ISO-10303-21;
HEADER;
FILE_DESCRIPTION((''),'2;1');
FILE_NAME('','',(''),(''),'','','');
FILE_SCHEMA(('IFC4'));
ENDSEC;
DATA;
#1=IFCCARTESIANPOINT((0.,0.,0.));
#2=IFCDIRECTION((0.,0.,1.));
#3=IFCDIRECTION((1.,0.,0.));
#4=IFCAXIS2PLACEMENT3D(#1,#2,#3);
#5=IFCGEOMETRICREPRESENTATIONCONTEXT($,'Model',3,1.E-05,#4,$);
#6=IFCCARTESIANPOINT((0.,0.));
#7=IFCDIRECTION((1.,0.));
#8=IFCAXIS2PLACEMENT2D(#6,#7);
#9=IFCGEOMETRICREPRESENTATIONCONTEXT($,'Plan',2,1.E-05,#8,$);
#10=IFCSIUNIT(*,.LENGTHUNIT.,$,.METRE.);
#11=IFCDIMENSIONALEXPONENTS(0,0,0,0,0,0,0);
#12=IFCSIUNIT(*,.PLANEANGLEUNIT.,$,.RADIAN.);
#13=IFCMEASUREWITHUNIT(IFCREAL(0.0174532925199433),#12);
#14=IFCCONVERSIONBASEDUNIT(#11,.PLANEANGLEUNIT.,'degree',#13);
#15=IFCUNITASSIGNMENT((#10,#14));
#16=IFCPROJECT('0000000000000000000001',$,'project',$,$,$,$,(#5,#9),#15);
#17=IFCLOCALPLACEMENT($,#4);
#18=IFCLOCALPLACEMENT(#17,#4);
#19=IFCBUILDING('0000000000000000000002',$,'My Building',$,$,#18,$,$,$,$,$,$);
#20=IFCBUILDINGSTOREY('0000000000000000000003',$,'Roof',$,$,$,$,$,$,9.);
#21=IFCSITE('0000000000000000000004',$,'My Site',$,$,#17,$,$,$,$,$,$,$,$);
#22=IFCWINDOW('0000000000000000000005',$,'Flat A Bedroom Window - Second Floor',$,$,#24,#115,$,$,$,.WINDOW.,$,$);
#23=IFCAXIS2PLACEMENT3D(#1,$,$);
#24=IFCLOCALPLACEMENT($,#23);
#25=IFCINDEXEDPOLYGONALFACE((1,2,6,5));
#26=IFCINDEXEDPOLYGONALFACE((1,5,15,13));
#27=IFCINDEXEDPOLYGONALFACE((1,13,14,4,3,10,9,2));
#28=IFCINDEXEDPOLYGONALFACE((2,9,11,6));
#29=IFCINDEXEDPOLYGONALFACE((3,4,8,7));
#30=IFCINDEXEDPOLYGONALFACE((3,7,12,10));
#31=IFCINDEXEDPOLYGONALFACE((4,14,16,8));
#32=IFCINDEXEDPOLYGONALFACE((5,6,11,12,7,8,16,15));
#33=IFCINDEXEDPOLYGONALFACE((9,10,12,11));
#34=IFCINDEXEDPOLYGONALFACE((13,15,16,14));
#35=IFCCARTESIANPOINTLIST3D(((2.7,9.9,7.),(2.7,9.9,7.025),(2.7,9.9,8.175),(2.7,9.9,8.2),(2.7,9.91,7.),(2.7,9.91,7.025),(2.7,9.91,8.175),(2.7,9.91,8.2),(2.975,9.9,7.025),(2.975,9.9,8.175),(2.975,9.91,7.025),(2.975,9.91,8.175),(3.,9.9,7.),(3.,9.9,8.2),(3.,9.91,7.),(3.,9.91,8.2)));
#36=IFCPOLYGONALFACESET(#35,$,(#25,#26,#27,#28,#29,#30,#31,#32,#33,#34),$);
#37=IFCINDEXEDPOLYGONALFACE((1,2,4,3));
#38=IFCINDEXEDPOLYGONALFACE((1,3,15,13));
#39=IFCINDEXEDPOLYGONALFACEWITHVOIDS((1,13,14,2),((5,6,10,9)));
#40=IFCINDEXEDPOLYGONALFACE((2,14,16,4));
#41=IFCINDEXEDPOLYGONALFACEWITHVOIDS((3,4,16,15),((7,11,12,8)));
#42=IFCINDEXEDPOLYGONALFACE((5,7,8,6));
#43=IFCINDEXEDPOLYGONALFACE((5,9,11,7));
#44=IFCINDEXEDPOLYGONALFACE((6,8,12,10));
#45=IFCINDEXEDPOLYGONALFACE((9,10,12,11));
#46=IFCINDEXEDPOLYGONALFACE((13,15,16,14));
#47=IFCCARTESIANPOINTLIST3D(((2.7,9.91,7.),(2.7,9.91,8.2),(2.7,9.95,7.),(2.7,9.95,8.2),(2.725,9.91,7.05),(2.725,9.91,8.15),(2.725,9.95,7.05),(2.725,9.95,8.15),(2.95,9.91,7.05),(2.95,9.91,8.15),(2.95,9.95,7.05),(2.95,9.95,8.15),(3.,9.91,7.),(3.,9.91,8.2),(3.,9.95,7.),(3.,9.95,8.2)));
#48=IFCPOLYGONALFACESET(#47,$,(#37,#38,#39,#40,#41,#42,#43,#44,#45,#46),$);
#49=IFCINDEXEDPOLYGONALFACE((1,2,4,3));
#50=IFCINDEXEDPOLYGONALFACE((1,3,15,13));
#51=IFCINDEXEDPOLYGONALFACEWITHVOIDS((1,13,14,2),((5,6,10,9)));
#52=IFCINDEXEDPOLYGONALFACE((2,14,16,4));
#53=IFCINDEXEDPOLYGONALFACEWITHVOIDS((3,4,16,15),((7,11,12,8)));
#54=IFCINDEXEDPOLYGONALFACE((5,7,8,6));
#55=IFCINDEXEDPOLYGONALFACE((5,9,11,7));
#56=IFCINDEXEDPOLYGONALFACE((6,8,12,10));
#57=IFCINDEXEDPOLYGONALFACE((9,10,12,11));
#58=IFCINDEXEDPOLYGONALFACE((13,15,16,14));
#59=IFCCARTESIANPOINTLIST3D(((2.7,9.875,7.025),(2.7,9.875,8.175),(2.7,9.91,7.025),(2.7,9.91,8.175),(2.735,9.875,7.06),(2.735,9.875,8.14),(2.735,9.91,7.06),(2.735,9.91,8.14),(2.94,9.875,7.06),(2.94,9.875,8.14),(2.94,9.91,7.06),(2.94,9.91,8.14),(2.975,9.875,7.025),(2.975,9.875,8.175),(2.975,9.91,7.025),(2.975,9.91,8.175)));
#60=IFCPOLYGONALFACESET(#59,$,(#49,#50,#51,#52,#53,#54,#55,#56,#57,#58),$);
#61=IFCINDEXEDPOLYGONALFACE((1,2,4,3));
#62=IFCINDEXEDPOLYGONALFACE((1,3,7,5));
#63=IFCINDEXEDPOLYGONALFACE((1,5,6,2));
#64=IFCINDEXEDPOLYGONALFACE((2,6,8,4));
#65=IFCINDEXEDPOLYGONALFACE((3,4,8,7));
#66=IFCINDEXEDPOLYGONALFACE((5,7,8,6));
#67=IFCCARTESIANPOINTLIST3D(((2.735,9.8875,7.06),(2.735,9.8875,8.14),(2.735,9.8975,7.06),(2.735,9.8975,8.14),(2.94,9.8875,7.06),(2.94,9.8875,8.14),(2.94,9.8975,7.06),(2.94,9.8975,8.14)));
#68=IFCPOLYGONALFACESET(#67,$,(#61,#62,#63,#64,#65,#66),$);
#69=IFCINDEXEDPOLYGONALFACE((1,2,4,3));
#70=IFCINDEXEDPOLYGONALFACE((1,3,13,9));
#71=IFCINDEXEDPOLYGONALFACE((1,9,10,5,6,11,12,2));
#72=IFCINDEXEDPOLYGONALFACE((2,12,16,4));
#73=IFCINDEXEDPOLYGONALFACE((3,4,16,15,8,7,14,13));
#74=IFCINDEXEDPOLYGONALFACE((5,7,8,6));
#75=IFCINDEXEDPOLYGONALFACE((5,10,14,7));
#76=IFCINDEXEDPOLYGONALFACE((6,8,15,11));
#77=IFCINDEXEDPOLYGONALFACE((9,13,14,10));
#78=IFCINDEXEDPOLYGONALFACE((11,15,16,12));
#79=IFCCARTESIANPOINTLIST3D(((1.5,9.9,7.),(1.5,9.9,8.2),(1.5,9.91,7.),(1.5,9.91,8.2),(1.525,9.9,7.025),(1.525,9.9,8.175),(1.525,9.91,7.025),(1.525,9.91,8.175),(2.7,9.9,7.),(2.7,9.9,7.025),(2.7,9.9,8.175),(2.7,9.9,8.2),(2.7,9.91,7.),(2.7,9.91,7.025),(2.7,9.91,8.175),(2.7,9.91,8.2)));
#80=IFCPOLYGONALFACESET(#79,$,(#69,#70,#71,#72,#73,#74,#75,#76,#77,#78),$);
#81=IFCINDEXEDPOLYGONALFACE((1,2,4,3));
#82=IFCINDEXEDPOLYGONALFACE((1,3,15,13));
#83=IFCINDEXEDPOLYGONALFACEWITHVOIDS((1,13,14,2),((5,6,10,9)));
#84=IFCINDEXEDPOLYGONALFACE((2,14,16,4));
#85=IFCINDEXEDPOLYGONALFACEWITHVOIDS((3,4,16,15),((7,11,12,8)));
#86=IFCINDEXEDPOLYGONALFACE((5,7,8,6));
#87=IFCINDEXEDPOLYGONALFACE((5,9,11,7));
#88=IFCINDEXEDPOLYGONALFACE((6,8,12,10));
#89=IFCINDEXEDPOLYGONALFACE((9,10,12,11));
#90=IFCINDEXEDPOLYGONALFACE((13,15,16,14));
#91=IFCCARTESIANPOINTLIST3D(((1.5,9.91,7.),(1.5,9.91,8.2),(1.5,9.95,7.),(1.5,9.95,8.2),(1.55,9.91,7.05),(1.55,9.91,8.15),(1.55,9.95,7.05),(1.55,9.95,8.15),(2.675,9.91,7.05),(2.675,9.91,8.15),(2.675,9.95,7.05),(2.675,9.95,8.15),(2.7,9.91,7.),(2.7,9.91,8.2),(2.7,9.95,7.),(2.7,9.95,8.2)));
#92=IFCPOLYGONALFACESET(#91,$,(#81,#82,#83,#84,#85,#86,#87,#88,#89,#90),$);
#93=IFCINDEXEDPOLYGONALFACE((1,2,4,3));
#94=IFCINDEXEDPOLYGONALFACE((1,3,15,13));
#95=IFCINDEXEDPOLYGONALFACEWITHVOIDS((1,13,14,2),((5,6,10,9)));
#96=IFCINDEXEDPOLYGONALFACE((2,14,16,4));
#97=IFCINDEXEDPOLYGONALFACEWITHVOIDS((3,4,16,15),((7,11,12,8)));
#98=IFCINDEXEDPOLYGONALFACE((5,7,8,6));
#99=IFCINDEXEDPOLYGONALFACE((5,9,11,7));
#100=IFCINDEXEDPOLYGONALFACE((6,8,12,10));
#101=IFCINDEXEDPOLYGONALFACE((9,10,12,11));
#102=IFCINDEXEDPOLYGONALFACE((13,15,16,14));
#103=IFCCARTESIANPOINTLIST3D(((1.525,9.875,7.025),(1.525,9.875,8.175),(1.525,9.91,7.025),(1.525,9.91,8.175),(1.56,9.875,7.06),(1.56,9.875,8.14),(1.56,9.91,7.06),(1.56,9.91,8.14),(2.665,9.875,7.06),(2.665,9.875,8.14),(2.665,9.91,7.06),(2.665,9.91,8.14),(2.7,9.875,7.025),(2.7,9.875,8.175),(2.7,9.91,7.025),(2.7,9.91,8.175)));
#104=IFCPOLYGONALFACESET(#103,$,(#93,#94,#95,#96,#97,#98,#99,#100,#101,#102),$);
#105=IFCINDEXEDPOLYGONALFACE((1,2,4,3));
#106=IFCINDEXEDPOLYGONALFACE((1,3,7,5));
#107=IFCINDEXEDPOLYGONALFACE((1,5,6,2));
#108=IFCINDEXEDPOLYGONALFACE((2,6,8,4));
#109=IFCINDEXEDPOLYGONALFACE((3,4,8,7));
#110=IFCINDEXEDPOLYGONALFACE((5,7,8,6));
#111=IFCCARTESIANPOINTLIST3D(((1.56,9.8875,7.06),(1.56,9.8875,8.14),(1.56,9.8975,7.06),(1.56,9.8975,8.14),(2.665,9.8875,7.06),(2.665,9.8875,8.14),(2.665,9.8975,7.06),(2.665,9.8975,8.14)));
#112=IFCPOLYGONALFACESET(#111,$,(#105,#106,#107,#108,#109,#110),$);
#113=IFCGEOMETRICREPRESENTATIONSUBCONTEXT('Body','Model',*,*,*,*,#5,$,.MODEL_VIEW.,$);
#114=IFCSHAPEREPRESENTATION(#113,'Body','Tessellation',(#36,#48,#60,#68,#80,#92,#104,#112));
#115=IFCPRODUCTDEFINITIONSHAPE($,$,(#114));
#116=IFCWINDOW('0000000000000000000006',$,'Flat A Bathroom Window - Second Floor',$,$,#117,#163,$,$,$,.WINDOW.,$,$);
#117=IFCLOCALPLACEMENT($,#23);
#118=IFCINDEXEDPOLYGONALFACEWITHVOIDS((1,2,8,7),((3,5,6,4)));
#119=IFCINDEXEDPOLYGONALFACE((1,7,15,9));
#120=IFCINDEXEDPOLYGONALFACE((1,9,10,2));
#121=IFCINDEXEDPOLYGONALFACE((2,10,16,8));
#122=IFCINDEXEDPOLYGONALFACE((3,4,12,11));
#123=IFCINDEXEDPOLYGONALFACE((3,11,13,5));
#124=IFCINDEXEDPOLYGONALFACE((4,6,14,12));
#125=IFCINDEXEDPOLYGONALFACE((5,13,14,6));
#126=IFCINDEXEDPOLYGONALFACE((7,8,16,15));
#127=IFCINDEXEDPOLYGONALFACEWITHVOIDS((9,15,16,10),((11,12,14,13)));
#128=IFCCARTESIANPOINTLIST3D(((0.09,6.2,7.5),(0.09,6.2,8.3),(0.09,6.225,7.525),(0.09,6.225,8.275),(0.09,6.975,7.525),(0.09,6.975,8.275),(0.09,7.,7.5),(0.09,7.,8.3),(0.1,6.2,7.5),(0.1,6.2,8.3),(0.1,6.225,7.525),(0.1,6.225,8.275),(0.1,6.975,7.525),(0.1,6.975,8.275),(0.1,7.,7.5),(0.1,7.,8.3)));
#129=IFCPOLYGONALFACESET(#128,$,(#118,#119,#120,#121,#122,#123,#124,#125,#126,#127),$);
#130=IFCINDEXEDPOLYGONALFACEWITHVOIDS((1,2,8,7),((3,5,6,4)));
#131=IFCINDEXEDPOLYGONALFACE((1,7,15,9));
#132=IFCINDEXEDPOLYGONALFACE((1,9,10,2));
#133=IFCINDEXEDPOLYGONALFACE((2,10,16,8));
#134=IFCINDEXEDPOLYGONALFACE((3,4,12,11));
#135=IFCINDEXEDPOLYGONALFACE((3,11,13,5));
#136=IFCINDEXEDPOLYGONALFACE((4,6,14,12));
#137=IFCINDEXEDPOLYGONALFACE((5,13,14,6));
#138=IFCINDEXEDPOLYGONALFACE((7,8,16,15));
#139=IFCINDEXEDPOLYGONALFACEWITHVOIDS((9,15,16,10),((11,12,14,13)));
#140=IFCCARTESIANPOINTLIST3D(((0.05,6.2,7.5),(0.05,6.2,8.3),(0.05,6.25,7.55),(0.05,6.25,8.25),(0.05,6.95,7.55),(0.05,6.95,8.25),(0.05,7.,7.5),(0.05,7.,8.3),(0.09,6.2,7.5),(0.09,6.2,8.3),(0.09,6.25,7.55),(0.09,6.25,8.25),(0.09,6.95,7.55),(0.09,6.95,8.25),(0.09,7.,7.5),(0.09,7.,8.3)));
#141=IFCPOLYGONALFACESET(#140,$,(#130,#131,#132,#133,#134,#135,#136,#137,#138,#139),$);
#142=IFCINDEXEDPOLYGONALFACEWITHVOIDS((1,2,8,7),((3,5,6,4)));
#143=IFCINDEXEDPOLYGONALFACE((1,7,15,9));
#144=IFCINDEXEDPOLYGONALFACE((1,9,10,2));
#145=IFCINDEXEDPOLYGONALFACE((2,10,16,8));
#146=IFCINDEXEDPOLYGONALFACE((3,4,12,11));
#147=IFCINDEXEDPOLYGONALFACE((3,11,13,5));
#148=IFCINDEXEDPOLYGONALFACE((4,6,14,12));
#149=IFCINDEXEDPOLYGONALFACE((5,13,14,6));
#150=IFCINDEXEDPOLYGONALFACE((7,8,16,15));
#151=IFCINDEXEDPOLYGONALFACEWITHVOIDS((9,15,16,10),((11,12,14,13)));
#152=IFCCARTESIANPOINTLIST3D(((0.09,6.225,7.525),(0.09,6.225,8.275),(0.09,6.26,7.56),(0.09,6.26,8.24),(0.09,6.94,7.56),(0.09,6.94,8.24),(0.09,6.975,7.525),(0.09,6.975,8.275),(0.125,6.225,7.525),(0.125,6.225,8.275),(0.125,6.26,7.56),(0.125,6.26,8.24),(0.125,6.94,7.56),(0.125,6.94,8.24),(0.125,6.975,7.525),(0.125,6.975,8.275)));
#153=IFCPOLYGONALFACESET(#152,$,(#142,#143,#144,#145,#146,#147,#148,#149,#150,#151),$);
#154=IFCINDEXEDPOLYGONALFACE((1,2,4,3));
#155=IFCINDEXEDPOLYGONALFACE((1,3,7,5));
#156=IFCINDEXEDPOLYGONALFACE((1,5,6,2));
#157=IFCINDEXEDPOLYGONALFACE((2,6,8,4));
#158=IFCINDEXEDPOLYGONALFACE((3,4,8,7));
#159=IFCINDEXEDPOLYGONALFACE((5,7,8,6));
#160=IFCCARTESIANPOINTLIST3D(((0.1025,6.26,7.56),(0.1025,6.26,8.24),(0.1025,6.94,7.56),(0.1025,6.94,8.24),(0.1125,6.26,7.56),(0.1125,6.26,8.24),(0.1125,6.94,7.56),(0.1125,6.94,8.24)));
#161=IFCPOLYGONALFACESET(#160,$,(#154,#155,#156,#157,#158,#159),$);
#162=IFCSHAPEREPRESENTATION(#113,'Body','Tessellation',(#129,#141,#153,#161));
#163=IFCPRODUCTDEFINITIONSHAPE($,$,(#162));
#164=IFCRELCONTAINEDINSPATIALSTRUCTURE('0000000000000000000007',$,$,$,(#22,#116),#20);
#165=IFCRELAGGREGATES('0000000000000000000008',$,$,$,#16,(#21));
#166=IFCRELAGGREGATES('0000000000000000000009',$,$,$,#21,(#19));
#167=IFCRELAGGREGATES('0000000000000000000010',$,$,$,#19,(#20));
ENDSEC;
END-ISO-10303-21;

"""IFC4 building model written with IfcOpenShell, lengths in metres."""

from ifc_helpers import new_model, entity, si_unit, converted_unit, frame, origin_with_axes, origin_2d_with_axis, place, context, subcontext, project, spatial, line, indexed_curve, outline, extrude, element, save


model = new_model("IFC4")

# Units and contexts
model_context = context("Model", 3, precision=1e-05, world=origin_with_axes())
plan_context = context("Plan", 2, precision=1e-05, world=origin_2d_with_axis())
body_context = subcontext(model_context, "Body", "Model", "MODEL_VIEW")
ifc_project = project(units=[si_unit("LENGTHUNIT", "METRE"), converted_unit("PLANEANGLEUNIT", "degree", entity("IfcReal", 0.0174532925199433), si_unit("PLANEANGLEUNIT", "RADIAN"), dimensions=[0, 0, 0, 0, 0, 0, 0])], contexts=[model_context, plan_context])

# Site, building, storey
site_placement = place(None, origin_with_axes())
site = spatial("IfcSite", under=ifc_project, at=site_placement, Name="My Site")
building_placement = place(site_placement, origin_with_axes())
building = spatial("IfcBuilding", under=site, at=building_placement, Name="My Building")
storey = spatial("IfcBuildingStorey", under=building, Name="Roof", Elevation=9.0)

# Windows
window_1_placement = place(None, frame((3.0, 10.0, 7.0), z_axis=(0.0, 0.0, 1.0), x_axis=(-1.0, 0.0, 0.0)))
element("IfcWindow", 1, at=window_1_placement, inside=storey, Name="Flat A Bedroom Window - Second Floor", PredefinedType="WINDOW", context=body_context, shape_type="SweptSolid", body=[
    extrude(outline(indexed_curve([(0.3, 0.0), (0.0, 0.0), (0.0, 1.2), (0.3, 1.2), (0.3, 1.175), (0.025, 1.175), (0.025, 0.025), (0.3, 0.025)], segments=[line(1, 2, 3, 4, 5, 6, 7, 8, 1)])), frame((0.0, 0.09, 0.0), z_axis=(0.0, -1.0, 0.0), x_axis=(1.0, 0.0, 0.0)), (0.0, 0.0, -1.0), 0.01),
    extrude(outline(indexed_curve([(0.0, 0.0), (0.3, 0.0), (0.3, 1.2), (0.0, 1.2)], segments=[line(1, 2, 3, 4, 1)]), holes=[indexed_curve([(0.05, 0.05), (0.275, 0.05), (0.275, 1.15), (0.05, 1.15)], segments=[line(1, 2, 3, 4, 1)])]), frame((0.0, 0.05, 0.0), z_axis=(0.0, -1.0, 0.0), x_axis=(1.0, 0.0, 0.0)), (0.0, 0.0, -1.0), 0.04),
    extrude(outline(indexed_curve([(0.0, 0.0), (0.275, 0.0), (0.275, 1.15), (0.0, 1.15)], segments=[line(1, 2, 3, 4, 1)]), holes=[indexed_curve([(0.035, 0.035), (0.24, 0.035), (0.24, 1.115), (0.035, 1.115)], segments=[line(1, 2, 3, 4, 1)])]), frame((0.025, 0.09, 0.025), z_axis=(0.0, -1.0, 0.0), x_axis=(1.0, 0.0, 0.0)), (0.0, 0.0, -1.0), 0.035),
    extrude(outline(indexed_curve([(0.035, 0.035), (0.24, 0.035), (0.24, 1.115), (0.035, 1.115)], segments=[line(1, 2, 3, 4, 1)])), frame((0.025, 0.1025, 0.025), z_axis=(0.0, -1.0, 0.0), x_axis=(1.0, 0.0, 0.0)), (0.0, 0.0, -1.0), 0.01),
    extrude(outline(indexed_curve([(0.0, 1.2), (1.2, 1.2), (1.2, 0.0), (0.0, 0.0), (0.0, 0.025), (1.175, 0.025), (1.175, 1.175), (0.0, 1.175)], segments=[line(1, 2, 3, 4, 5, 6, 7, 8, 1)])), frame((0.3, 0.09, 0.0), z_axis=(0.0, -1.0, 0.0), x_axis=(1.0, 0.0, 0.0)), (0.0, 0.0, -1.0), 0.01),
    extrude(outline(indexed_curve([(0.0, 0.0), (1.2, 0.0), (1.2, 1.2), (0.0, 1.2)], segments=[line(1, 2, 3, 4, 1)]), holes=[indexed_curve([(0.025, 0.05), (1.15, 0.05), (1.15, 1.15), (0.025, 1.15)], segments=[line(1, 2, 3, 4, 1)])]), frame((0.3, 0.05, 0.0), z_axis=(0.0, -1.0, 0.0), x_axis=(1.0, 0.0, 0.0)), (0.0, 0.0, -1.0), 0.04),
    extrude(outline(indexed_curve([(0.0, 0.0), (1.175, 0.0), (1.175, 1.15), (0.0, 1.15)], segments=[line(1, 2, 3, 4, 1)]), holes=[indexed_curve([(0.035, 0.035), (1.14, 0.035), (1.14, 1.115), (0.035, 1.115)], segments=[line(1, 2, 3, 4, 1)])]), frame((0.3, 0.09, 0.025), z_axis=(0.0, -1.0, 0.0), x_axis=(1.0, 0.0, 0.0)), (0.0, 0.0, -1.0), 0.035),
    extrude(outline(indexed_curve([(0.035, 0.035), (1.14, 0.035), (1.14, 1.115), (0.035, 1.115)], segments=[line(1, 2, 3, 4, 1)])), frame((0.3, 0.1025, 0.025), z_axis=(0.0, -1.0, 0.0), x_axis=(1.0, 0.0, 0.0)), (0.0, 0.0, -1.0), 0.01),
])
window_2_placement = place(None, frame((0.0, 7.0, 7.5), z_axis=(0.0, 0.0, 1.0), x_axis=(0.0, -1.0, 0.0)))
element("IfcWindow", 2, at=window_2_placement, inside=storey, Name="Flat A Bathroom Window - Second Floor", PredefinedType="WINDOW", context=body_context, shape_type="SweptSolid", body=[
    extrude(outline(indexed_curve([(0.0, 0.0), (0.8, 0.0), (0.8, 0.8), (0.0, 0.8)], segments=[line(1, 2, 3, 4, 1)]), holes=[indexed_curve([(0.025, 0.025), (0.775, 0.025), (0.775, 0.775), (0.025, 0.775)], segments=[line(1, 2, 3, 4, 1)])]), frame((0.0, 0.09, 0.0), z_axis=(0.0, -1.0, 0.0), x_axis=(1.0, 0.0, 0.0)), (0.0, 0.0, -1.0), 0.01),
    extrude(outline(indexed_curve([(0.0, 0.0), (0.8, 0.0), (0.8, 0.8), (0.0, 0.8)], segments=[line(1, 2, 3, 4, 1)]), holes=[indexed_curve([(0.05, 0.05), (0.75, 0.05), (0.75, 0.75), (0.05, 0.75)], segments=[line(1, 2, 3, 4, 1)])]), frame((0.0, 0.05, 0.0), z_axis=(0.0, -1.0, 0.0), x_axis=(1.0, 0.0, 0.0)), (0.0, 0.0, -1.0), 0.04),
    extrude(outline(indexed_curve([(0.0, 0.0), (0.75, 0.0), (0.75, 0.75), (0.0, 0.75)], segments=[line(1, 2, 3, 4, 1)]), holes=[indexed_curve([(0.035, 0.035), (0.715, 0.035), (0.715, 0.715), (0.035, 0.715)], segments=[line(1, 2, 3, 4, 1)])]), frame((0.025, 0.09, 0.025), z_axis=(0.0, -1.0, 0.0), x_axis=(1.0, 0.0, 0.0)), (0.0, 0.0, -1.0), 0.035),
    extrude(outline(indexed_curve([(0.035, 0.035), (0.715, 0.035), (0.715, 0.715), (0.035, 0.715)], segments=[line(1, 2, 3, 4, 1)])), frame((0.025, 0.1025, 0.025), z_axis=(0.0, -1.0, 0.0), x_axis=(1.0, 0.0, 0.0)), (0.0, 0.0, -1.0), 0.01),
])

save(model, "model.ifc")
